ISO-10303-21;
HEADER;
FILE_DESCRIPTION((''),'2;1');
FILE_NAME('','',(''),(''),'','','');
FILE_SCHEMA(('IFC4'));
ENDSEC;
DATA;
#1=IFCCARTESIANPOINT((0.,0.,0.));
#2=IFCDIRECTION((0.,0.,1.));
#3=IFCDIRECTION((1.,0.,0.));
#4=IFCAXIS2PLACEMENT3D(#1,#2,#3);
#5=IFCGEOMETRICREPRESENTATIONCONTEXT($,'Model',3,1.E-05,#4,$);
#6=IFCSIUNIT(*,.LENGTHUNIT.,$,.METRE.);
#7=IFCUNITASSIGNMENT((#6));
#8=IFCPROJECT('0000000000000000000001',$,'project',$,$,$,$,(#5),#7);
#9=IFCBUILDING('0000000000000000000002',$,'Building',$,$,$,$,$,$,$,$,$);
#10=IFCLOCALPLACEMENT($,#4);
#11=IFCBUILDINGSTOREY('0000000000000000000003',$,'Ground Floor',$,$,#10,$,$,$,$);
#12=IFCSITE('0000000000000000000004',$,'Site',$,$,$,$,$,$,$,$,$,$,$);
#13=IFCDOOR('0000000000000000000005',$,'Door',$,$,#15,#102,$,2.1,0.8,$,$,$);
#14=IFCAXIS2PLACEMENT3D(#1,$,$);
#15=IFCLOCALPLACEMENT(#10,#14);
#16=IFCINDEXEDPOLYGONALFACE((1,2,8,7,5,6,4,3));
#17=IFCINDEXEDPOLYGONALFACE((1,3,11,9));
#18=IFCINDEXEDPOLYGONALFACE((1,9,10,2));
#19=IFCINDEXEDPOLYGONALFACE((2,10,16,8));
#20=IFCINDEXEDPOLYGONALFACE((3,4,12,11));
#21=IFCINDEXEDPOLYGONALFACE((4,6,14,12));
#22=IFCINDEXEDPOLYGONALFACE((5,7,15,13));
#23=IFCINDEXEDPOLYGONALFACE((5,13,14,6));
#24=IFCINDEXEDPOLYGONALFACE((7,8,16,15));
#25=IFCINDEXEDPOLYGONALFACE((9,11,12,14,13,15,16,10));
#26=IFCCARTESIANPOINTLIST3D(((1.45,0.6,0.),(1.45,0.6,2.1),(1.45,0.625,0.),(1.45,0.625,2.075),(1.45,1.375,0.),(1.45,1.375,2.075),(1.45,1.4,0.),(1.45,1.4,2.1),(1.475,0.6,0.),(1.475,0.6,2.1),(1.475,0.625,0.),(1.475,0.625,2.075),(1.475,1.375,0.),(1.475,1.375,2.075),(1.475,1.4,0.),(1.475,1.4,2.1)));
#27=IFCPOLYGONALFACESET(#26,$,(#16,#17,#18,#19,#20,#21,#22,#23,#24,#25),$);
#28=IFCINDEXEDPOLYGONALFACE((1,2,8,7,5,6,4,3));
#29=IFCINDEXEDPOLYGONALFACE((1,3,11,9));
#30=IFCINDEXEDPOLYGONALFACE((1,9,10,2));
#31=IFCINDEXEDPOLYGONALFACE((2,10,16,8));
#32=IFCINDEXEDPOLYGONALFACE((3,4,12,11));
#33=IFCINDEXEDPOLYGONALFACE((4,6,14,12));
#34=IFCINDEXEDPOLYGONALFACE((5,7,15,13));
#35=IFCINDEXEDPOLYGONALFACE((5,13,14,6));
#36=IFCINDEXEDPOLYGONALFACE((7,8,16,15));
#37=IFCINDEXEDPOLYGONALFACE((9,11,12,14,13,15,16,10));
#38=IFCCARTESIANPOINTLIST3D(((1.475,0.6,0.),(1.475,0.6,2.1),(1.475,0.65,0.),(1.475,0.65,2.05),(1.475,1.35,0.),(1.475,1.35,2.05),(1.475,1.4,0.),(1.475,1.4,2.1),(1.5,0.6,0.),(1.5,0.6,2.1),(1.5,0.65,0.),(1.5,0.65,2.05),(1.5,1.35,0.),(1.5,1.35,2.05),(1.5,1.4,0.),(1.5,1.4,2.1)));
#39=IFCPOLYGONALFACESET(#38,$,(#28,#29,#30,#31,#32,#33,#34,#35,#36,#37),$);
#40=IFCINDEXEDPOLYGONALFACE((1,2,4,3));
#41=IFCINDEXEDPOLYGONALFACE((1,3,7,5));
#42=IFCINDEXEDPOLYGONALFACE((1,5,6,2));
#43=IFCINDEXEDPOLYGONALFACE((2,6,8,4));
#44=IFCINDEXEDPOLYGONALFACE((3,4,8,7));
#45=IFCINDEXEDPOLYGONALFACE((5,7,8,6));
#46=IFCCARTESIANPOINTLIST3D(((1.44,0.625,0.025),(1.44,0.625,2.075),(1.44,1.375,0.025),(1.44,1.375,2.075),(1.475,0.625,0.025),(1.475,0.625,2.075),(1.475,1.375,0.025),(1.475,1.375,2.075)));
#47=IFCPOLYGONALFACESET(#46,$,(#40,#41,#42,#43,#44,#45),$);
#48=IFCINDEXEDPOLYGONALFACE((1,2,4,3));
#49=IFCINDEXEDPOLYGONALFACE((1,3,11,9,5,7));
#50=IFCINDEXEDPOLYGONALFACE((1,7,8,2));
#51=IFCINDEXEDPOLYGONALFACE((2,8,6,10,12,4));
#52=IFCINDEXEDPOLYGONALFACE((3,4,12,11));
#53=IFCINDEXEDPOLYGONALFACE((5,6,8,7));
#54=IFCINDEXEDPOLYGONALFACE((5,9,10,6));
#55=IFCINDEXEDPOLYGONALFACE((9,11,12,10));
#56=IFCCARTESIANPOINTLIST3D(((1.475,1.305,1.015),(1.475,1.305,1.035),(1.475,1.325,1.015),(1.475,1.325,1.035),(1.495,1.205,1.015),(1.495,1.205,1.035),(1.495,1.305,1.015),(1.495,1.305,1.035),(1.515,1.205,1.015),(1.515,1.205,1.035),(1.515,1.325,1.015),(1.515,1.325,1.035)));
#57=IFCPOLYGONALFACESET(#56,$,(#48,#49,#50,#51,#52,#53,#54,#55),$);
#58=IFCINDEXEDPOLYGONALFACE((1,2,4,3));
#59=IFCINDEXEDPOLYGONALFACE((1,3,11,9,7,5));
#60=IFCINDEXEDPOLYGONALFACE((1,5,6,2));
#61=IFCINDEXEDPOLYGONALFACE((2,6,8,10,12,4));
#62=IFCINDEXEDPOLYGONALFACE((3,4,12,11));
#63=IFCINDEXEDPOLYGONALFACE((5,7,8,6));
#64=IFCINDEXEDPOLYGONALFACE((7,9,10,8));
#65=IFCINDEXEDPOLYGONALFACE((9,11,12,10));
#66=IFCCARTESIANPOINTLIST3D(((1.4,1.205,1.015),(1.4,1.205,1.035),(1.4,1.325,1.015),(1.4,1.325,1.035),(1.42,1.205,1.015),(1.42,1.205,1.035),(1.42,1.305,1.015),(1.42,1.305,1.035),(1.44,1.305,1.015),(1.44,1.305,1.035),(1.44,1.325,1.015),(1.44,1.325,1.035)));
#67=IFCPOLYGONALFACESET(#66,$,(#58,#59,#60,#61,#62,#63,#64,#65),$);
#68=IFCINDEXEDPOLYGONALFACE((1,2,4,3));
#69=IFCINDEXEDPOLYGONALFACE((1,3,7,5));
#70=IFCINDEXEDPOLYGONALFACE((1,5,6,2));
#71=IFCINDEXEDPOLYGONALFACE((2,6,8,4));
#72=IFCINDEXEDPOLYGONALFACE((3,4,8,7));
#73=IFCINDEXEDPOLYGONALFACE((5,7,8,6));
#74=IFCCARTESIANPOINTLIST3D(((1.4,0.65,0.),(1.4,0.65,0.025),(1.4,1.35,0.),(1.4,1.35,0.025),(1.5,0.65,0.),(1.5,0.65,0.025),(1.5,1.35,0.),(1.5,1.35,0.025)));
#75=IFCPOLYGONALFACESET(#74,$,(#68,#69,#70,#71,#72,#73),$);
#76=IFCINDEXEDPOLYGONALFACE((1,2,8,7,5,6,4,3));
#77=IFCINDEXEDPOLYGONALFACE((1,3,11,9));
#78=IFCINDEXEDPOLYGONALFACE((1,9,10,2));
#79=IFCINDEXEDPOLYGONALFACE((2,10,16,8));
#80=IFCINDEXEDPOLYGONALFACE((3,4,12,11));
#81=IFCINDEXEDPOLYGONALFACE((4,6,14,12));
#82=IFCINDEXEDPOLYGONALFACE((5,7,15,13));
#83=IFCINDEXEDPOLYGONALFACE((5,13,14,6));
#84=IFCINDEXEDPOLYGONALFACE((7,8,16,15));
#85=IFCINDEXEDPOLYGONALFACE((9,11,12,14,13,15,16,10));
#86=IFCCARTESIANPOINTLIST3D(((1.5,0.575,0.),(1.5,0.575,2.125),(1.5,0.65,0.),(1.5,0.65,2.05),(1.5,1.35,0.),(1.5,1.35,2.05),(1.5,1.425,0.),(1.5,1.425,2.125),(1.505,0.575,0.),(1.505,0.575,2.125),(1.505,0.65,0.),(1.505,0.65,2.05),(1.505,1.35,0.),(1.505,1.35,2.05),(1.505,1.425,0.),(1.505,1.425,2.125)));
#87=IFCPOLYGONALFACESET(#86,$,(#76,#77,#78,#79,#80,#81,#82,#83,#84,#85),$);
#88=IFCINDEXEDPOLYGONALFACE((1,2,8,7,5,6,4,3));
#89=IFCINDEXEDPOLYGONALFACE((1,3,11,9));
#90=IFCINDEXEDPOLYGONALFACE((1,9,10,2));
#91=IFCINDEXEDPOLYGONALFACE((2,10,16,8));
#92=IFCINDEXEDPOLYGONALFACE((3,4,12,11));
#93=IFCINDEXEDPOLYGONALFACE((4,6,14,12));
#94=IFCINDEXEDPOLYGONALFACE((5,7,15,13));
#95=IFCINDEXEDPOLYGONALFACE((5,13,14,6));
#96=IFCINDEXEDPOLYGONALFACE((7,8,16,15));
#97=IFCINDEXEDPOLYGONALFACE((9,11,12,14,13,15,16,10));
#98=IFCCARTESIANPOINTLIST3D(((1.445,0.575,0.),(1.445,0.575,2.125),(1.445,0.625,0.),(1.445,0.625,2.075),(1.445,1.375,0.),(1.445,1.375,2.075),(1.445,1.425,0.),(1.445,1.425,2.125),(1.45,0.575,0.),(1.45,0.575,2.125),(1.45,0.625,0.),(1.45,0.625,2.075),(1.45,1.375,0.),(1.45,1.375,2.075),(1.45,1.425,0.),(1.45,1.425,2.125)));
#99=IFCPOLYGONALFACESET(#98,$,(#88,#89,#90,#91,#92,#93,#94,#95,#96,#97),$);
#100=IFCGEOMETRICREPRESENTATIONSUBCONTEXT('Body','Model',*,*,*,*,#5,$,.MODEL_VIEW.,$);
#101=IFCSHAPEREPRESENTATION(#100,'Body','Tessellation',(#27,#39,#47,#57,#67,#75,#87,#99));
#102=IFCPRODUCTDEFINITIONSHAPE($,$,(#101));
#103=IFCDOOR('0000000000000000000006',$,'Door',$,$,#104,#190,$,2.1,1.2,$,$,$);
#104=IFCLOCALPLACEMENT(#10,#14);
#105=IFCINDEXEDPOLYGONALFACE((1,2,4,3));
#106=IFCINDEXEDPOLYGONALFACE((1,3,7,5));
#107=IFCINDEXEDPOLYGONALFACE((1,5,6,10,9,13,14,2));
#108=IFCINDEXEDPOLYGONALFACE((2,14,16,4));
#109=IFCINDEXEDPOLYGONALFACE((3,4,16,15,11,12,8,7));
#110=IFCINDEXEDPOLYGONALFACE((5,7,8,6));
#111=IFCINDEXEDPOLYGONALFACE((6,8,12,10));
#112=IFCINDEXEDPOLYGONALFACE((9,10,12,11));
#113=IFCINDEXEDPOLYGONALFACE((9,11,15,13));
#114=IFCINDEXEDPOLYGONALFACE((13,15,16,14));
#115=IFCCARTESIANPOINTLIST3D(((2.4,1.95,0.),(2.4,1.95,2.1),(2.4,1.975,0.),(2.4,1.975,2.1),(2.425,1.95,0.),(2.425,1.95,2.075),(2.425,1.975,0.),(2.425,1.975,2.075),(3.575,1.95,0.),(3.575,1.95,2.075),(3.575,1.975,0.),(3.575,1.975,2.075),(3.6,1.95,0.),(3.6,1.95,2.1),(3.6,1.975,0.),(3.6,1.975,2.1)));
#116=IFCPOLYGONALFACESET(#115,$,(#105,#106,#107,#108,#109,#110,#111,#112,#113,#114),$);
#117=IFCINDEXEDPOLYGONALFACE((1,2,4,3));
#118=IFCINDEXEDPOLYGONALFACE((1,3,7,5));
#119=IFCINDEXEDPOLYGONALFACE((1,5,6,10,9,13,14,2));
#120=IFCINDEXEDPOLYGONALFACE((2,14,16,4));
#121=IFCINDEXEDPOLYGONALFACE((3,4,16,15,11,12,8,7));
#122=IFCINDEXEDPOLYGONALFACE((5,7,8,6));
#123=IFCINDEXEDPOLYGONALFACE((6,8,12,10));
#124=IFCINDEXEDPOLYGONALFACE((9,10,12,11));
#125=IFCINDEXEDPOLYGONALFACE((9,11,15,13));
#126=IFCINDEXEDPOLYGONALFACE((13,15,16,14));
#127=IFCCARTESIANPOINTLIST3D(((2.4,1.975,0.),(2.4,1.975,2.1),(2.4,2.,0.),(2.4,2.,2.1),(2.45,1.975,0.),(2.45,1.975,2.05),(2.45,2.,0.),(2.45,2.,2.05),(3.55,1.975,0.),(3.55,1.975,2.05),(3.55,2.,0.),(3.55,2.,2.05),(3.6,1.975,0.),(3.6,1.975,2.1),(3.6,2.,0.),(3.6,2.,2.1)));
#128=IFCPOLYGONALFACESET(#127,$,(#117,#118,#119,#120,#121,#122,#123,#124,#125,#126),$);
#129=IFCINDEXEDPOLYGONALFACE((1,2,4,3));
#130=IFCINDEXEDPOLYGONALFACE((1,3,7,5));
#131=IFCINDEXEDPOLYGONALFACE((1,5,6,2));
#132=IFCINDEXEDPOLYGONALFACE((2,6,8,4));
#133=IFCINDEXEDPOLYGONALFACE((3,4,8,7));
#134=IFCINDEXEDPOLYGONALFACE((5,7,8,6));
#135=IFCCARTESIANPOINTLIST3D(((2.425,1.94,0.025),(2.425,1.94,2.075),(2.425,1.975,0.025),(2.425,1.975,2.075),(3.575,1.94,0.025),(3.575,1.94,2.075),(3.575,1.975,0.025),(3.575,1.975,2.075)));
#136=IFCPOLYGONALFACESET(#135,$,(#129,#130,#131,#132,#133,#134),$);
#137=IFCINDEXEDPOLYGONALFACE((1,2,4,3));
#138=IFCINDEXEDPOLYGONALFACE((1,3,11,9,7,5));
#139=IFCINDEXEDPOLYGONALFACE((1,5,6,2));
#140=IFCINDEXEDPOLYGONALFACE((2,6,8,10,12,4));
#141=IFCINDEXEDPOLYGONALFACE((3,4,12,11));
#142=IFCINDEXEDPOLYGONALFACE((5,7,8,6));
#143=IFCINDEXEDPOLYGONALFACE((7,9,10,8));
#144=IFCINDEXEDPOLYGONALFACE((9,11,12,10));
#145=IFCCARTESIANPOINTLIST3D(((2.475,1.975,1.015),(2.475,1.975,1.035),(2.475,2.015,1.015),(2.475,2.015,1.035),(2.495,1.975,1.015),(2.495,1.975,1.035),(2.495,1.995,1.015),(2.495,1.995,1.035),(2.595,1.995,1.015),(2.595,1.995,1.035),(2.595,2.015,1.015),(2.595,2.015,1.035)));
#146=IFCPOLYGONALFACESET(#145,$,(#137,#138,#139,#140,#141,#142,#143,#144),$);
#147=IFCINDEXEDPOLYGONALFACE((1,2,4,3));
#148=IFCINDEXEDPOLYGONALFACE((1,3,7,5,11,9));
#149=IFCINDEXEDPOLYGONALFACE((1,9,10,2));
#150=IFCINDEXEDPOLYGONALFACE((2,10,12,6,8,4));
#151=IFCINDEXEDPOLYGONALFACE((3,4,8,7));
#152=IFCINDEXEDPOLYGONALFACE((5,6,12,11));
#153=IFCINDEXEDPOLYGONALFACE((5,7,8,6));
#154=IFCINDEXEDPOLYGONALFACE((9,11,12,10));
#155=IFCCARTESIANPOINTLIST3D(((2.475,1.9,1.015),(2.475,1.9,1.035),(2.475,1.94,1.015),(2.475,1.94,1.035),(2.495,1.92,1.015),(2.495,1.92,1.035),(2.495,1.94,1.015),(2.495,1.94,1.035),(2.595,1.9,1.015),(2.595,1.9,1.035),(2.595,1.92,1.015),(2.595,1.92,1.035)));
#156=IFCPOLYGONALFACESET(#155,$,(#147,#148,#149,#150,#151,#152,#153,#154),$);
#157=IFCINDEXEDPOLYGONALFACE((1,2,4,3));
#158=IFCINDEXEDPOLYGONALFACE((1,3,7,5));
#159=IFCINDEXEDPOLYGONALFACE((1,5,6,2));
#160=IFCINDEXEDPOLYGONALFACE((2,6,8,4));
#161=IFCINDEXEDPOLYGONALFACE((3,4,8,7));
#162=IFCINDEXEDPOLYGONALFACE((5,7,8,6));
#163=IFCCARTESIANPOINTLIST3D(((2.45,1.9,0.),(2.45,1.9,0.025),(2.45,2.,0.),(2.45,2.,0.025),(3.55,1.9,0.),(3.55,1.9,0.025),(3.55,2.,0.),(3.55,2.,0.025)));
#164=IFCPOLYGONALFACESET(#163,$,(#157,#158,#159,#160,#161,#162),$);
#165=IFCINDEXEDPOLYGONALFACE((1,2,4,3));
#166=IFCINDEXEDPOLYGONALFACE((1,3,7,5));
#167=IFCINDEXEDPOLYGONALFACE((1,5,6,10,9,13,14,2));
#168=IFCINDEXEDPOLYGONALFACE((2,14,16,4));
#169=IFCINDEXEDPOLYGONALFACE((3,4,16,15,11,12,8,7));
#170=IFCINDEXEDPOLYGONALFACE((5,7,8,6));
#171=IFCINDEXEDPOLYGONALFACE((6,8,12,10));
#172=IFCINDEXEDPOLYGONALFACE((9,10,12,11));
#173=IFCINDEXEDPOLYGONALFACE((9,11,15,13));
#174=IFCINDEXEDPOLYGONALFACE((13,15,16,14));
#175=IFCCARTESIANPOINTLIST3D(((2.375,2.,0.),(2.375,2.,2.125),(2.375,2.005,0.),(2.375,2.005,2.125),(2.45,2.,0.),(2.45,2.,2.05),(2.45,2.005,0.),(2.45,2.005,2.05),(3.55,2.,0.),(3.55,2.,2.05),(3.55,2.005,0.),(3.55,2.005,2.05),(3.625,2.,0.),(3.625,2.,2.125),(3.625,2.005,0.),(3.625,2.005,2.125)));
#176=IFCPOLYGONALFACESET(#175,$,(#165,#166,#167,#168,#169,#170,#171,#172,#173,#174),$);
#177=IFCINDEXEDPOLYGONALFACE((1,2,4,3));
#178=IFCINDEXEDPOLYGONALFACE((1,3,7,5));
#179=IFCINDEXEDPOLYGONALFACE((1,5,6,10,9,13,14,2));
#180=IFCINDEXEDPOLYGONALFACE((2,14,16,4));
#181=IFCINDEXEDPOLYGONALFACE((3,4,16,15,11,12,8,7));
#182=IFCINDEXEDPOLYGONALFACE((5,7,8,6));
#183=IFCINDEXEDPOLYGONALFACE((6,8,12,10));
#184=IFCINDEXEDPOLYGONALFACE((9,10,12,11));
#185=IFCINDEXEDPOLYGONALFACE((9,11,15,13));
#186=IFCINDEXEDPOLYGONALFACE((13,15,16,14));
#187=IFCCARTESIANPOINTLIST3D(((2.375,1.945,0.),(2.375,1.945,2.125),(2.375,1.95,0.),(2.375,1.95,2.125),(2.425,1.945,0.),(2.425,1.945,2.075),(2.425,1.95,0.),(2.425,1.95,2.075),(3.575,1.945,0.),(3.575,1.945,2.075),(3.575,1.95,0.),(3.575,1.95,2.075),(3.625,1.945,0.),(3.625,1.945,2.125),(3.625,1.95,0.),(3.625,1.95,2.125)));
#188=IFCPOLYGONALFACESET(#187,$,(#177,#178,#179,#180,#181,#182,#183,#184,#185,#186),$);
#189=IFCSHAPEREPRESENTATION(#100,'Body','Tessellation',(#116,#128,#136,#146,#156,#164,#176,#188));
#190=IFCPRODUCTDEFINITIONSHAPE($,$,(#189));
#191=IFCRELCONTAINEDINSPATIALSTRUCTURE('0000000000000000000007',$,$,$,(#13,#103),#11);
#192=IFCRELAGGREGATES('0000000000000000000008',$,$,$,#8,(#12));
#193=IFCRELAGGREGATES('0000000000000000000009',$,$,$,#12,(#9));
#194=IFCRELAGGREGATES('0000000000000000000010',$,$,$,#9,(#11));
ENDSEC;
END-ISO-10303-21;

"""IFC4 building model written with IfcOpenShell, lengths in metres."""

from ifc_helpers import new_model, si_unit, frame, origin_with_axes, place, context, subcontext, project, spatial, line, indexed_curve, outline, extrude, element, save


model = new_model("IFC4")

# Units and contexts
model_context = context("Model", 3, precision=1e-05, world=origin_with_axes())
body_context = subcontext(model_context, "Body", "Model", "MODEL_VIEW")
ifc_project = project(units=[si_unit("LENGTHUNIT", "METRE")], contexts=[model_context])

# Site, building, storey
site = spatial("IfcSite", under=ifc_project, Name="Site")
building = spatial("IfcBuilding", under=site, Name="Building")
storey_placement = place(None, origin_with_axes())
storey = spatial("IfcBuildingStorey", under=building, at=storey_placement, Name="Ground Floor")

# Doors
door_1_placement = place(storey_placement, frame((1.5, 0.6, 0.0), z_axis=(0.0, 0.0, 1.0), x_axis=(0.0, 1.0, 0.0)))
element("IfcDoor", 1, at=door_1_placement, inside=storey, Name="Door", OverallHeight=2.1, OverallWidth=0.8, context=body_context, shape_type="SweptSolid", body=[
    extrude(outline(indexed_curve([(0.0, 0.0), (0.0, 2.1), (0.8, 2.1), (0.8, 0.0), (0.775, 0.0), (0.775, 2.075), (0.025, 2.075), (0.025, 0.0)], segments=[line(1, 2, 3, 4, 5, 6, 7, 8, 1)])), frame((0.0, 0.025, 0.0), z_axis=(0.0, -1.0, 0.0), x_axis=(1.0, 0.0, 0.0)), (0.0, 0.0, -1.0), 0.025),
    extrude(outline(indexed_curve([(0.0, 0.0), (0.0, 2.1), (0.8, 2.1), (0.8, 0.0), (0.75, 0.0), (0.75, 2.05), (0.05, 2.05), (0.05, 0.0)], segments=[line(1, 2, 3, 4, 5, 6, 7, 8, 1)])), frame((0.0, 0.0, 0.0), z_axis=(0.0, -1.0, 0.0), x_axis=(1.0, 0.0, 0.0)), (0.0, 0.0, -1.0), 0.025),
    extrude(outline(indexed_curve([(0.0, 0.0), (0.75, 0.0), (0.75, 0.035), (0.0, 0.035)], segments=[line(1, 2, 3, 4, 1)])), frame((0.025, 0.025, 0.025), z_axis=(0.0, 0.0, 1.0), x_axis=(1.0, 0.0, 0.0)), (0.0, 0.0, 1.0), 2.05),
    extrude(outline(indexed_curve([(0.0, 0.0), (0.0, -0.04), (-0.12, -0.04), (-0.12, -0.02), (-0.02, -0.02), (-0.02, 0.0)], segments=[line(1, 2, 3, 4, 5, 6, 1)])), frame((0.725, 0.025, 1.015), z_axis=(0.0, 0.0, 1.0), x_axis=(1.0, 0.0, 0.0)), (0.0, 0.0, 1.0), 0.02),
    extrude(outline(indexed_curve([(0.0, 0.0), (0.0, 0.04), (-0.12, 0.04), (-0.12, 0.02), (-0.02, 0.02), (-0.02, 0.0)], segments=[line(1, 2, 3, 4, 5, 6, 1)])), frame((0.725, 0.06, 1.015), z_axis=(0.0, 0.0, 1.0), x_axis=(1.0, 0.0, 0.0)), (0.0, 0.0, 1.0), 0.02),
    extrude(outline(indexed_curve([(0.0, 0.0), (0.7, 0.0), (0.7, 0.1), (0.0, 0.1)], segments=[line(1, 2, 3, 4, 1)])), frame((0.05, 0.0, 0.0), z_axis=(0.0, 0.0, 1.0), x_axis=(1.0, 0.0, 0.0)), (0.0, 0.0, 1.0), 0.025),
    extrude(outline(indexed_curve([(0.0, 0.0), (0.0, 2.125), (0.85, 2.125), (0.85, 0.0), (0.775, 0.0), (0.775, 2.05), (0.075, 2.05), (0.075, 0.0)], segments=[line(1, 2, 3, 4, 5, 6, 7, 8, 1)])), frame((-0.025, -0.005, 0.0), z_axis=(0.0, -1.0, 0.0), x_axis=(1.0, 0.0, 0.0)), (0.0, 0.0, -1.0), 0.005),
    extrude(outline(indexed_curve([(0.0, 0.0), (0.0, 2.125), (0.85, 2.125), (0.85, 0.0), (0.8, 0.0), (0.8, 2.075), (0.05, 2.075), (0.05, 0.0)], segments=[line(1, 2, 3, 4, 5, 6, 7, 8, 1)])), frame((-0.025, 0.05, 0.0), z_axis=(0.0, -1.0, 0.0), x_axis=(1.0, 0.0, 0.0)), (0.0, 0.0, -1.0), 0.005),
])
door_2_placement = place(storey_placement, frame((3.6, 2.0, 0.0), z_axis=(0.0, 0.0, 1.0), x_axis=(-1.0, 0.0, 0.0)))
element("IfcDoor", 2, at=door_2_placement, inside=storey, Name="Door", OverallHeight=2.1, OverallWidth=1.2, context=body_context, shape_type="SweptSolid", body=[
    extrude(outline(indexed_curve([(0.0, 0.0), (0.0, 2.1), (1.2, 2.1), (1.2, 0.0), (1.175, 0.0), (1.175, 2.075), (0.025, 2.075), (0.025, 0.0)], segments=[line(1, 2, 3, 4, 5, 6, 7, 8, 1)])), frame((0.0, 0.025, 0.0), z_axis=(0.0, -1.0, 0.0), x_axis=(1.0, 0.0, 0.0)), (0.0, 0.0, -1.0), 0.025),
    extrude(outline(indexed_curve([(0.0, 0.0), (0.0, 2.1), (1.2, 2.1), (1.2, 0.0), (1.15, 0.0), (1.15, 2.05), (0.05, 2.05), (0.05, 0.0)], segments=[line(1, 2, 3, 4, 5, 6, 7, 8, 1)])), frame((0.0, 0.0, 0.0), z_axis=(0.0, -1.0, 0.0), x_axis=(1.0, 0.0, 0.0)), (0.0, 0.0, -1.0), 0.025),
    extrude(outline(indexed_curve([(0.0, 0.0), (1.15, 0.0), (1.15, 0.035), (0.0, 0.035)], segments=[line(1, 2, 3, 4, 1)])), frame((0.025, 0.025, 0.025), z_axis=(0.0, 0.0, 1.0), x_axis=(1.0, 0.0, 0.0)), (0.0, 0.0, 1.0), 2.05),
    extrude(outline(indexed_curve([(0.0, 0.0), (0.0, -0.04), (-0.12, -0.04), (-0.12, -0.02), (-0.02, -0.02), (-0.02, 0.0)], segments=[line(1, 2, 3, 4, 5, 6, 1)])), frame((1.125, 0.025, 1.015), z_axis=(0.0, 0.0, 1.0), x_axis=(1.0, 0.0, 0.0)), (0.0, 0.0, 1.0), 0.02),
    extrude(outline(indexed_curve([(0.0, 0.0), (0.0, 0.04), (-0.12, 0.04), (-0.12, 0.02), (-0.02, 0.02), (-0.02, 0.0)], segments=[line(1, 2, 3, 4, 5, 6, 1)])), frame((1.125, 0.06, 1.015), z_axis=(0.0, 0.0, 1.0), x_axis=(1.0, 0.0, 0.0)), (0.0, 0.0, 1.0), 0.02),
    extrude(outline(indexed_curve([(0.0, 0.0), (1.1, 0.0), (1.1, 0.1), (0.0, 0.1)], segments=[line(1, 2, 3, 4, 1)])), frame((0.05, 0.0, 0.0), z_axis=(0.0, 0.0, 1.0), x_axis=(1.0, 0.0, 0.0)), (0.0, 0.0, 1.0), 0.025),
    extrude(outline(indexed_curve([(0.0, 0.0), (0.0, 2.125), (1.25, 2.125), (1.25, 0.0), (1.175, 0.0), (1.175, 2.05), (0.075, 2.05), (0.075, 0.0)], segments=[line(1, 2, 3, 4, 5, 6, 7, 8, 1)])), frame((-0.025, -0.005, 0.0), z_axis=(0.0, -1.0, 0.0), x_axis=(1.0, 0.0, 0.0)), (0.0, 0.0, -1.0), 0.005),
    extrude(outline(indexed_curve([(0.0, 0.0), (0.0, 2.125), (1.25, 2.125), (1.25, 0.0), (1.2, 0.0), (1.2, 2.075), (0.05, 2.075), (0.05, 0.0)], segments=[line(1, 2, 3, 4, 5, 6, 7, 8, 1)])), frame((-0.025, 0.05, 0.0), z_axis=(0.0, -1.0, 0.0), x_axis=(1.0, 0.0, 0.0)), (0.0, 0.0, -1.0), 0.005),
])

save(model, "model.ifc")
